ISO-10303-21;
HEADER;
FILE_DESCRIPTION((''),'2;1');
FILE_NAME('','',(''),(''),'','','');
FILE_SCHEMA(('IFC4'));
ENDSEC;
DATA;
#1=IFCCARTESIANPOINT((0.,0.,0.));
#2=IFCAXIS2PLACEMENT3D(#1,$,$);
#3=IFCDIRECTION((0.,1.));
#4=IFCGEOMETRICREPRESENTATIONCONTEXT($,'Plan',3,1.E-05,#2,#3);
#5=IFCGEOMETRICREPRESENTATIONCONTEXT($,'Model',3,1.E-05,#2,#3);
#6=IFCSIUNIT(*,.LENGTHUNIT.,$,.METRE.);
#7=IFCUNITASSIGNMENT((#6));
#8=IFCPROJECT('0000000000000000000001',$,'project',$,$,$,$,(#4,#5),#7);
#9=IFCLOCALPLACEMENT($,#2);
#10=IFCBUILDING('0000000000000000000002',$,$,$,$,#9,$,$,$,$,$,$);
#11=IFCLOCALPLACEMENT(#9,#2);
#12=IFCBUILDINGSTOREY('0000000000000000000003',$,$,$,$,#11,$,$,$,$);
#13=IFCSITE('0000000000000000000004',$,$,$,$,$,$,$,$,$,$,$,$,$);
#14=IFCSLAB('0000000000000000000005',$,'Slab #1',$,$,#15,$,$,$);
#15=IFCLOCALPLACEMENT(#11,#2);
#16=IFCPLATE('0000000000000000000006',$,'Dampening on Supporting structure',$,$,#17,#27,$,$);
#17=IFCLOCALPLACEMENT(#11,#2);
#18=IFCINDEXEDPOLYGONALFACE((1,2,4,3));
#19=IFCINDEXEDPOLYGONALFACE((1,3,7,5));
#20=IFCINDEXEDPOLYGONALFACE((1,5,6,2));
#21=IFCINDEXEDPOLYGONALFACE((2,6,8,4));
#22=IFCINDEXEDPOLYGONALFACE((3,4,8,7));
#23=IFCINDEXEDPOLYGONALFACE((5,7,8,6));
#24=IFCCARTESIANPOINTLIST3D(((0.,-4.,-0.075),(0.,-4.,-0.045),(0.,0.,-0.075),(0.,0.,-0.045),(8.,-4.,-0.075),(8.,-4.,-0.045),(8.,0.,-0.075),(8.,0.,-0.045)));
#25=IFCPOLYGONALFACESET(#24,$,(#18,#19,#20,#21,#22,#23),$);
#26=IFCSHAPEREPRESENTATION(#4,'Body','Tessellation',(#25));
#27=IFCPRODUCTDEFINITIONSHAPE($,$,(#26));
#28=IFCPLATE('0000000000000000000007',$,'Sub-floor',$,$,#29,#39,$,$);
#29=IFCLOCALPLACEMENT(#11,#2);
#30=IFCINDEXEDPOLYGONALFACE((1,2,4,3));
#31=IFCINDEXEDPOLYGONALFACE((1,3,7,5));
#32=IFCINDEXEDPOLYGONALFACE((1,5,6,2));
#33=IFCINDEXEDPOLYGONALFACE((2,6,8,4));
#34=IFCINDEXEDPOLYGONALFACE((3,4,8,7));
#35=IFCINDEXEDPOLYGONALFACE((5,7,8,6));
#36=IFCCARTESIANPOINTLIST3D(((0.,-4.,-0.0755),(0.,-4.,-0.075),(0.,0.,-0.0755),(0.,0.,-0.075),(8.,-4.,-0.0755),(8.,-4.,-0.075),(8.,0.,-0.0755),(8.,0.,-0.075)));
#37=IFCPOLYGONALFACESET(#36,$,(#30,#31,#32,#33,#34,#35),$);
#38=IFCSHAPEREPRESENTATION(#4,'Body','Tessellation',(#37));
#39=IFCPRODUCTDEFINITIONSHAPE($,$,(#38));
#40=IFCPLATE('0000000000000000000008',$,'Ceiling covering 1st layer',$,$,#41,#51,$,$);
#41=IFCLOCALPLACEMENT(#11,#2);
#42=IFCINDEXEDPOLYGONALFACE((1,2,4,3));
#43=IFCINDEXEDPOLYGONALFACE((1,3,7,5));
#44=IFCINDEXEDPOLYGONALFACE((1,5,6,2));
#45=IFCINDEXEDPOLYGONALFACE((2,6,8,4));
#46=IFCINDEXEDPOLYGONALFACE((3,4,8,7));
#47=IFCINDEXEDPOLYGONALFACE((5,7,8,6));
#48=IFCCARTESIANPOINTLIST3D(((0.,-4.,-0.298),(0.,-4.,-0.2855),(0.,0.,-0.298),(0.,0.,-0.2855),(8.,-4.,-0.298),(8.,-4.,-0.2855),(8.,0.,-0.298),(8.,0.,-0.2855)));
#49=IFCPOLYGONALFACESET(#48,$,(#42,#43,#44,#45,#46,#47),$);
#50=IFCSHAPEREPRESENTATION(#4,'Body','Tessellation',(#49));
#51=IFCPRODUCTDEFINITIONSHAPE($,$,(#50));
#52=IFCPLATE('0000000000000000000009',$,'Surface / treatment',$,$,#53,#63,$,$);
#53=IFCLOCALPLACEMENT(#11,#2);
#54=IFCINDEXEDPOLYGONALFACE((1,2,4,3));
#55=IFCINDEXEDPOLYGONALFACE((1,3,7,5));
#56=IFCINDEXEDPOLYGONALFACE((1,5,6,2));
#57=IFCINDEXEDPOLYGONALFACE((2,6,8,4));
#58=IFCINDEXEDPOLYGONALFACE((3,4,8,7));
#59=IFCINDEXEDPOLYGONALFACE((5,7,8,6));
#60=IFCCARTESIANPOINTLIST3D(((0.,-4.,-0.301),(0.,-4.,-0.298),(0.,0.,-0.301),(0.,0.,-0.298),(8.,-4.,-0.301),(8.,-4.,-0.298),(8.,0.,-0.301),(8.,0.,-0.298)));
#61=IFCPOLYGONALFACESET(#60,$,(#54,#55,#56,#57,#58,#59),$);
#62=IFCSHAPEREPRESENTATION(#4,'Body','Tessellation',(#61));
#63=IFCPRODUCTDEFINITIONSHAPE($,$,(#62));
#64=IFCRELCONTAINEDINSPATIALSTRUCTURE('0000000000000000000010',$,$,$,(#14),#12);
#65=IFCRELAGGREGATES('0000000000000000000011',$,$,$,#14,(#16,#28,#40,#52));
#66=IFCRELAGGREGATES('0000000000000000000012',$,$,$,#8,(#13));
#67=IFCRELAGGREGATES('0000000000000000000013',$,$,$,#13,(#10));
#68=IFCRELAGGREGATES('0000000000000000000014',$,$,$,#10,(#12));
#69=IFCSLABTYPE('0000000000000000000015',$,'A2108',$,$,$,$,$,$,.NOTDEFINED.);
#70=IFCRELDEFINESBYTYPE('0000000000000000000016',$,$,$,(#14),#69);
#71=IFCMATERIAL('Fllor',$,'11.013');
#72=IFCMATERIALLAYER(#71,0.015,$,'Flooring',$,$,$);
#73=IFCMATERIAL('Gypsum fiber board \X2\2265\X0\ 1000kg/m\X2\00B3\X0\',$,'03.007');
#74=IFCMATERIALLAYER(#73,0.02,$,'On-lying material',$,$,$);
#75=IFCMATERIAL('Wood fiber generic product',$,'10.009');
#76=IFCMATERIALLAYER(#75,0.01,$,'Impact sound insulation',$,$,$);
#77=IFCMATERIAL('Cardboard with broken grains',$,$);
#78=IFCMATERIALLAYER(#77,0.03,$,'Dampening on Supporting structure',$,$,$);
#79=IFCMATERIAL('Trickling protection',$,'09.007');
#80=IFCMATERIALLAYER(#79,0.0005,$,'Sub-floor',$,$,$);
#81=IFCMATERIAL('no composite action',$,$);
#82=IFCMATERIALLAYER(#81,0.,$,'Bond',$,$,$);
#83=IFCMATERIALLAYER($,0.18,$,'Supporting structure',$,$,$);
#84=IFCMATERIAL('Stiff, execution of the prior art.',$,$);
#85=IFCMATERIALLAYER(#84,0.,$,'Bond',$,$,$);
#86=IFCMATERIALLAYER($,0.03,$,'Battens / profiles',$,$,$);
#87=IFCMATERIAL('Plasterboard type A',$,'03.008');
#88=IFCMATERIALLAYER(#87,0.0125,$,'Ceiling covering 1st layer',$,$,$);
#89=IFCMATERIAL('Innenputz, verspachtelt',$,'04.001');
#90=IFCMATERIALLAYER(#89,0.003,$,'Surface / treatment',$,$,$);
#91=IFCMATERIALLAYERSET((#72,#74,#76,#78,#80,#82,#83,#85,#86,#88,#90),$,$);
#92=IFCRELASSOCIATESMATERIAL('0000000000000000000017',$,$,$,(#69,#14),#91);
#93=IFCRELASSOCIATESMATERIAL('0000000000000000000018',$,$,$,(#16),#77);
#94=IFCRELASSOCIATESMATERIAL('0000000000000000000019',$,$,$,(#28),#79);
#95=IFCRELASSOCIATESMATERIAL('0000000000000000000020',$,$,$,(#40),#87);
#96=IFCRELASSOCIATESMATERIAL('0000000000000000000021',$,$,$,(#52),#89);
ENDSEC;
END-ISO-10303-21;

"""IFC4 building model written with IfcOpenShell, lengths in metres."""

from ifc_helpers import new_model, si_unit, direction, frame, frame_2d, origin, place, context, project, spatial, rectangle, extrude, material, layer, layer_set, type_object, element, aggregate, save


model = new_model("IFC4")

# Units and contexts
plan_context = context("Plan", 3, precision=1e-05, world=origin(), true_north=direction((0.0, 1.0)))
model_context = context("Model", 3, precision=1e-05, world=origin(), true_north=direction((0.0, 1.0)))
ifc_project = project(units=[si_unit("LENGTHUNIT", "METRE")], contexts=[plan_context, model_context])

# Site, building, storey
site = spatial("IfcSite", under=ifc_project)
building_placement = place(None, origin())
building = spatial("IfcBuilding", under=site, at=building_placement)
storey_placement = place(building_placement, origin())
storey = spatial("IfcBuildingStorey", under=building, at=storey_placement)

# Slab, plates
ifc_material_1 = material(Name="Fllor", Category="11.013")
ifc_layer_1 = layer(ifc_material_1, 0.015, Name="Flooring")
ifc_material_2 = material(Name="Gypsum fiber board ≥ 1000kg/m³", Category="03.007")
ifc_layer_2 = layer(ifc_material_2, 0.02, Name="On-lying material")
ifc_material_3 = material(Name="Wood fiber generic product", Category="10.009")
ifc_layer_3 = layer(ifc_material_3, 0.01, Name="Impact sound insulation")
ifc_material_4 = material(Name="Cardboard with broken grains")
ifc_layer_4 = layer(ifc_material_4, 0.03, Name="Dampening on Supporting structure")
ifc_material_5 = material(Name="Trickling protection", Category="09.007")
ifc_layer_5 = layer(ifc_material_5, 0.0005, Name="Sub-floor")
ifc_material_6 = material(Name="no composite action")
ifc_layer_6 = layer(ifc_material_6, 0.0, Name="Bond")
ifc_layer_7 = layer(None, 0.18, Name="Supporting structure")
ifc_material_7 = material(Name="Stiff, execution of the prior art.")
ifc_layer_8 = layer(ifc_material_7, 0.0, Name="Bond")
ifc_layer_9 = layer(None, 0.03, Name="Battens / profiles")
ifc_material_8 = material(Name="Plasterboard type A", Category="03.008")
ifc_layer_10 = layer(ifc_material_8, 0.0125, Name="Ceiling covering 1st layer")
ifc_material_9 = material(Name="Innenputz, verspachtelt", Category="04.001")
ifc_layer_11 = layer(ifc_material_9, 0.003, Name="Surface / treatment")
ifc_layer_set = layer_set([ifc_layer_1, ifc_layer_2, ifc_layer_3, ifc_layer_4, ifc_layer_5, ifc_layer_6, ifc_layer_7, ifc_layer_8, ifc_layer_9, ifc_layer_10, ifc_layer_11])
slab_type = type_object("IfcSlabType", Name="A2108", PredefinedType="NOTDEFINED", material=ifc_layer_set)
slab_placement = place(None, frame((0.0, 0.0, 0.0), z_axis=(0.0, 0.0, -1.0), x_axis=(1.0, 0.0, 0.0)))
slab = element("IfcSlab", 1, at=slab_placement, inside=storey, type_object=slab_type, material=ifc_layer_set, Name="Slab #1")
plate_1_placement = place(slab_placement, origin())
plate_1 = element("IfcPlate", 2, at=plate_1_placement, material=ifc_material_4, Name="Dampening on Supporting structure", context=plan_context, shape_type="SweptSolid", body=[
    extrude(rectangle(XDim=8.0, YDim=4.0, at=frame_2d((4.0, 2.0), x_axis=(1.0, 0.0))), frame((0.0, 0.0, 0.045), z_axis=(0.0, 0.0, 1.0), x_axis=(1.0, 0.0, 0.0)), (0.0, 0.0, 1.0), 0.03),
])
plate_2_placement = place(slab_placement, origin())
plate_2 = element("IfcPlate", 3, at=plate_2_placement, material=ifc_material_5, Name="Sub-floor", context=plan_context, shape_type="SweptSolid", body=[
    extrude(rectangle(XDim=8.0, YDim=4.0, at=frame_2d((4.0, 2.0), x_axis=(1.0, 0.0))), frame((0.0, 0.0, 0.075), z_axis=(0.0, 0.0, 1.0), x_axis=(1.0, 0.0, 0.0)), (0.0, 0.0, 1.0), 0.0005),
])
plate_3_placement = place(slab_placement, origin())
plate_3 = element("IfcPlate", 4, at=plate_3_placement, material=ifc_material_8, Name="Ceiling covering 1st layer", context=plan_context, shape_type="SweptSolid", body=[
    extrude(rectangle(XDim=8.0, YDim=4.0, at=frame_2d((4.0, 2.0), x_axis=(1.0, 0.0))), frame((0.0, 0.0, 0.2855), z_axis=(0.0, 0.0, 1.0), x_axis=(1.0, 0.0, 0.0)), (0.0, 0.0, 1.0), 0.0125),
])
plate_4_placement = place(slab_placement, origin())
plate_4 = element("IfcPlate", 5, at=plate_4_placement, material=ifc_material_9, Name="Surface / treatment", context=plan_context, shape_type="SweptSolid", body=[
    extrude(rectangle(XDim=8.0, YDim=4.0, at=frame_2d((4.0, 2.0), x_axis=(1.0, 0.0))), frame((0.0, 0.0, 0.298), z_axis=(0.0, 0.0, 1.0), x_axis=(1.0, 0.0, 0.0)), (0.0, 0.0, 1.0), 0.003),
])
aggregate(slab, [plate_1, plate_2, plate_3, plate_4])

save(model, "model.ifc")
